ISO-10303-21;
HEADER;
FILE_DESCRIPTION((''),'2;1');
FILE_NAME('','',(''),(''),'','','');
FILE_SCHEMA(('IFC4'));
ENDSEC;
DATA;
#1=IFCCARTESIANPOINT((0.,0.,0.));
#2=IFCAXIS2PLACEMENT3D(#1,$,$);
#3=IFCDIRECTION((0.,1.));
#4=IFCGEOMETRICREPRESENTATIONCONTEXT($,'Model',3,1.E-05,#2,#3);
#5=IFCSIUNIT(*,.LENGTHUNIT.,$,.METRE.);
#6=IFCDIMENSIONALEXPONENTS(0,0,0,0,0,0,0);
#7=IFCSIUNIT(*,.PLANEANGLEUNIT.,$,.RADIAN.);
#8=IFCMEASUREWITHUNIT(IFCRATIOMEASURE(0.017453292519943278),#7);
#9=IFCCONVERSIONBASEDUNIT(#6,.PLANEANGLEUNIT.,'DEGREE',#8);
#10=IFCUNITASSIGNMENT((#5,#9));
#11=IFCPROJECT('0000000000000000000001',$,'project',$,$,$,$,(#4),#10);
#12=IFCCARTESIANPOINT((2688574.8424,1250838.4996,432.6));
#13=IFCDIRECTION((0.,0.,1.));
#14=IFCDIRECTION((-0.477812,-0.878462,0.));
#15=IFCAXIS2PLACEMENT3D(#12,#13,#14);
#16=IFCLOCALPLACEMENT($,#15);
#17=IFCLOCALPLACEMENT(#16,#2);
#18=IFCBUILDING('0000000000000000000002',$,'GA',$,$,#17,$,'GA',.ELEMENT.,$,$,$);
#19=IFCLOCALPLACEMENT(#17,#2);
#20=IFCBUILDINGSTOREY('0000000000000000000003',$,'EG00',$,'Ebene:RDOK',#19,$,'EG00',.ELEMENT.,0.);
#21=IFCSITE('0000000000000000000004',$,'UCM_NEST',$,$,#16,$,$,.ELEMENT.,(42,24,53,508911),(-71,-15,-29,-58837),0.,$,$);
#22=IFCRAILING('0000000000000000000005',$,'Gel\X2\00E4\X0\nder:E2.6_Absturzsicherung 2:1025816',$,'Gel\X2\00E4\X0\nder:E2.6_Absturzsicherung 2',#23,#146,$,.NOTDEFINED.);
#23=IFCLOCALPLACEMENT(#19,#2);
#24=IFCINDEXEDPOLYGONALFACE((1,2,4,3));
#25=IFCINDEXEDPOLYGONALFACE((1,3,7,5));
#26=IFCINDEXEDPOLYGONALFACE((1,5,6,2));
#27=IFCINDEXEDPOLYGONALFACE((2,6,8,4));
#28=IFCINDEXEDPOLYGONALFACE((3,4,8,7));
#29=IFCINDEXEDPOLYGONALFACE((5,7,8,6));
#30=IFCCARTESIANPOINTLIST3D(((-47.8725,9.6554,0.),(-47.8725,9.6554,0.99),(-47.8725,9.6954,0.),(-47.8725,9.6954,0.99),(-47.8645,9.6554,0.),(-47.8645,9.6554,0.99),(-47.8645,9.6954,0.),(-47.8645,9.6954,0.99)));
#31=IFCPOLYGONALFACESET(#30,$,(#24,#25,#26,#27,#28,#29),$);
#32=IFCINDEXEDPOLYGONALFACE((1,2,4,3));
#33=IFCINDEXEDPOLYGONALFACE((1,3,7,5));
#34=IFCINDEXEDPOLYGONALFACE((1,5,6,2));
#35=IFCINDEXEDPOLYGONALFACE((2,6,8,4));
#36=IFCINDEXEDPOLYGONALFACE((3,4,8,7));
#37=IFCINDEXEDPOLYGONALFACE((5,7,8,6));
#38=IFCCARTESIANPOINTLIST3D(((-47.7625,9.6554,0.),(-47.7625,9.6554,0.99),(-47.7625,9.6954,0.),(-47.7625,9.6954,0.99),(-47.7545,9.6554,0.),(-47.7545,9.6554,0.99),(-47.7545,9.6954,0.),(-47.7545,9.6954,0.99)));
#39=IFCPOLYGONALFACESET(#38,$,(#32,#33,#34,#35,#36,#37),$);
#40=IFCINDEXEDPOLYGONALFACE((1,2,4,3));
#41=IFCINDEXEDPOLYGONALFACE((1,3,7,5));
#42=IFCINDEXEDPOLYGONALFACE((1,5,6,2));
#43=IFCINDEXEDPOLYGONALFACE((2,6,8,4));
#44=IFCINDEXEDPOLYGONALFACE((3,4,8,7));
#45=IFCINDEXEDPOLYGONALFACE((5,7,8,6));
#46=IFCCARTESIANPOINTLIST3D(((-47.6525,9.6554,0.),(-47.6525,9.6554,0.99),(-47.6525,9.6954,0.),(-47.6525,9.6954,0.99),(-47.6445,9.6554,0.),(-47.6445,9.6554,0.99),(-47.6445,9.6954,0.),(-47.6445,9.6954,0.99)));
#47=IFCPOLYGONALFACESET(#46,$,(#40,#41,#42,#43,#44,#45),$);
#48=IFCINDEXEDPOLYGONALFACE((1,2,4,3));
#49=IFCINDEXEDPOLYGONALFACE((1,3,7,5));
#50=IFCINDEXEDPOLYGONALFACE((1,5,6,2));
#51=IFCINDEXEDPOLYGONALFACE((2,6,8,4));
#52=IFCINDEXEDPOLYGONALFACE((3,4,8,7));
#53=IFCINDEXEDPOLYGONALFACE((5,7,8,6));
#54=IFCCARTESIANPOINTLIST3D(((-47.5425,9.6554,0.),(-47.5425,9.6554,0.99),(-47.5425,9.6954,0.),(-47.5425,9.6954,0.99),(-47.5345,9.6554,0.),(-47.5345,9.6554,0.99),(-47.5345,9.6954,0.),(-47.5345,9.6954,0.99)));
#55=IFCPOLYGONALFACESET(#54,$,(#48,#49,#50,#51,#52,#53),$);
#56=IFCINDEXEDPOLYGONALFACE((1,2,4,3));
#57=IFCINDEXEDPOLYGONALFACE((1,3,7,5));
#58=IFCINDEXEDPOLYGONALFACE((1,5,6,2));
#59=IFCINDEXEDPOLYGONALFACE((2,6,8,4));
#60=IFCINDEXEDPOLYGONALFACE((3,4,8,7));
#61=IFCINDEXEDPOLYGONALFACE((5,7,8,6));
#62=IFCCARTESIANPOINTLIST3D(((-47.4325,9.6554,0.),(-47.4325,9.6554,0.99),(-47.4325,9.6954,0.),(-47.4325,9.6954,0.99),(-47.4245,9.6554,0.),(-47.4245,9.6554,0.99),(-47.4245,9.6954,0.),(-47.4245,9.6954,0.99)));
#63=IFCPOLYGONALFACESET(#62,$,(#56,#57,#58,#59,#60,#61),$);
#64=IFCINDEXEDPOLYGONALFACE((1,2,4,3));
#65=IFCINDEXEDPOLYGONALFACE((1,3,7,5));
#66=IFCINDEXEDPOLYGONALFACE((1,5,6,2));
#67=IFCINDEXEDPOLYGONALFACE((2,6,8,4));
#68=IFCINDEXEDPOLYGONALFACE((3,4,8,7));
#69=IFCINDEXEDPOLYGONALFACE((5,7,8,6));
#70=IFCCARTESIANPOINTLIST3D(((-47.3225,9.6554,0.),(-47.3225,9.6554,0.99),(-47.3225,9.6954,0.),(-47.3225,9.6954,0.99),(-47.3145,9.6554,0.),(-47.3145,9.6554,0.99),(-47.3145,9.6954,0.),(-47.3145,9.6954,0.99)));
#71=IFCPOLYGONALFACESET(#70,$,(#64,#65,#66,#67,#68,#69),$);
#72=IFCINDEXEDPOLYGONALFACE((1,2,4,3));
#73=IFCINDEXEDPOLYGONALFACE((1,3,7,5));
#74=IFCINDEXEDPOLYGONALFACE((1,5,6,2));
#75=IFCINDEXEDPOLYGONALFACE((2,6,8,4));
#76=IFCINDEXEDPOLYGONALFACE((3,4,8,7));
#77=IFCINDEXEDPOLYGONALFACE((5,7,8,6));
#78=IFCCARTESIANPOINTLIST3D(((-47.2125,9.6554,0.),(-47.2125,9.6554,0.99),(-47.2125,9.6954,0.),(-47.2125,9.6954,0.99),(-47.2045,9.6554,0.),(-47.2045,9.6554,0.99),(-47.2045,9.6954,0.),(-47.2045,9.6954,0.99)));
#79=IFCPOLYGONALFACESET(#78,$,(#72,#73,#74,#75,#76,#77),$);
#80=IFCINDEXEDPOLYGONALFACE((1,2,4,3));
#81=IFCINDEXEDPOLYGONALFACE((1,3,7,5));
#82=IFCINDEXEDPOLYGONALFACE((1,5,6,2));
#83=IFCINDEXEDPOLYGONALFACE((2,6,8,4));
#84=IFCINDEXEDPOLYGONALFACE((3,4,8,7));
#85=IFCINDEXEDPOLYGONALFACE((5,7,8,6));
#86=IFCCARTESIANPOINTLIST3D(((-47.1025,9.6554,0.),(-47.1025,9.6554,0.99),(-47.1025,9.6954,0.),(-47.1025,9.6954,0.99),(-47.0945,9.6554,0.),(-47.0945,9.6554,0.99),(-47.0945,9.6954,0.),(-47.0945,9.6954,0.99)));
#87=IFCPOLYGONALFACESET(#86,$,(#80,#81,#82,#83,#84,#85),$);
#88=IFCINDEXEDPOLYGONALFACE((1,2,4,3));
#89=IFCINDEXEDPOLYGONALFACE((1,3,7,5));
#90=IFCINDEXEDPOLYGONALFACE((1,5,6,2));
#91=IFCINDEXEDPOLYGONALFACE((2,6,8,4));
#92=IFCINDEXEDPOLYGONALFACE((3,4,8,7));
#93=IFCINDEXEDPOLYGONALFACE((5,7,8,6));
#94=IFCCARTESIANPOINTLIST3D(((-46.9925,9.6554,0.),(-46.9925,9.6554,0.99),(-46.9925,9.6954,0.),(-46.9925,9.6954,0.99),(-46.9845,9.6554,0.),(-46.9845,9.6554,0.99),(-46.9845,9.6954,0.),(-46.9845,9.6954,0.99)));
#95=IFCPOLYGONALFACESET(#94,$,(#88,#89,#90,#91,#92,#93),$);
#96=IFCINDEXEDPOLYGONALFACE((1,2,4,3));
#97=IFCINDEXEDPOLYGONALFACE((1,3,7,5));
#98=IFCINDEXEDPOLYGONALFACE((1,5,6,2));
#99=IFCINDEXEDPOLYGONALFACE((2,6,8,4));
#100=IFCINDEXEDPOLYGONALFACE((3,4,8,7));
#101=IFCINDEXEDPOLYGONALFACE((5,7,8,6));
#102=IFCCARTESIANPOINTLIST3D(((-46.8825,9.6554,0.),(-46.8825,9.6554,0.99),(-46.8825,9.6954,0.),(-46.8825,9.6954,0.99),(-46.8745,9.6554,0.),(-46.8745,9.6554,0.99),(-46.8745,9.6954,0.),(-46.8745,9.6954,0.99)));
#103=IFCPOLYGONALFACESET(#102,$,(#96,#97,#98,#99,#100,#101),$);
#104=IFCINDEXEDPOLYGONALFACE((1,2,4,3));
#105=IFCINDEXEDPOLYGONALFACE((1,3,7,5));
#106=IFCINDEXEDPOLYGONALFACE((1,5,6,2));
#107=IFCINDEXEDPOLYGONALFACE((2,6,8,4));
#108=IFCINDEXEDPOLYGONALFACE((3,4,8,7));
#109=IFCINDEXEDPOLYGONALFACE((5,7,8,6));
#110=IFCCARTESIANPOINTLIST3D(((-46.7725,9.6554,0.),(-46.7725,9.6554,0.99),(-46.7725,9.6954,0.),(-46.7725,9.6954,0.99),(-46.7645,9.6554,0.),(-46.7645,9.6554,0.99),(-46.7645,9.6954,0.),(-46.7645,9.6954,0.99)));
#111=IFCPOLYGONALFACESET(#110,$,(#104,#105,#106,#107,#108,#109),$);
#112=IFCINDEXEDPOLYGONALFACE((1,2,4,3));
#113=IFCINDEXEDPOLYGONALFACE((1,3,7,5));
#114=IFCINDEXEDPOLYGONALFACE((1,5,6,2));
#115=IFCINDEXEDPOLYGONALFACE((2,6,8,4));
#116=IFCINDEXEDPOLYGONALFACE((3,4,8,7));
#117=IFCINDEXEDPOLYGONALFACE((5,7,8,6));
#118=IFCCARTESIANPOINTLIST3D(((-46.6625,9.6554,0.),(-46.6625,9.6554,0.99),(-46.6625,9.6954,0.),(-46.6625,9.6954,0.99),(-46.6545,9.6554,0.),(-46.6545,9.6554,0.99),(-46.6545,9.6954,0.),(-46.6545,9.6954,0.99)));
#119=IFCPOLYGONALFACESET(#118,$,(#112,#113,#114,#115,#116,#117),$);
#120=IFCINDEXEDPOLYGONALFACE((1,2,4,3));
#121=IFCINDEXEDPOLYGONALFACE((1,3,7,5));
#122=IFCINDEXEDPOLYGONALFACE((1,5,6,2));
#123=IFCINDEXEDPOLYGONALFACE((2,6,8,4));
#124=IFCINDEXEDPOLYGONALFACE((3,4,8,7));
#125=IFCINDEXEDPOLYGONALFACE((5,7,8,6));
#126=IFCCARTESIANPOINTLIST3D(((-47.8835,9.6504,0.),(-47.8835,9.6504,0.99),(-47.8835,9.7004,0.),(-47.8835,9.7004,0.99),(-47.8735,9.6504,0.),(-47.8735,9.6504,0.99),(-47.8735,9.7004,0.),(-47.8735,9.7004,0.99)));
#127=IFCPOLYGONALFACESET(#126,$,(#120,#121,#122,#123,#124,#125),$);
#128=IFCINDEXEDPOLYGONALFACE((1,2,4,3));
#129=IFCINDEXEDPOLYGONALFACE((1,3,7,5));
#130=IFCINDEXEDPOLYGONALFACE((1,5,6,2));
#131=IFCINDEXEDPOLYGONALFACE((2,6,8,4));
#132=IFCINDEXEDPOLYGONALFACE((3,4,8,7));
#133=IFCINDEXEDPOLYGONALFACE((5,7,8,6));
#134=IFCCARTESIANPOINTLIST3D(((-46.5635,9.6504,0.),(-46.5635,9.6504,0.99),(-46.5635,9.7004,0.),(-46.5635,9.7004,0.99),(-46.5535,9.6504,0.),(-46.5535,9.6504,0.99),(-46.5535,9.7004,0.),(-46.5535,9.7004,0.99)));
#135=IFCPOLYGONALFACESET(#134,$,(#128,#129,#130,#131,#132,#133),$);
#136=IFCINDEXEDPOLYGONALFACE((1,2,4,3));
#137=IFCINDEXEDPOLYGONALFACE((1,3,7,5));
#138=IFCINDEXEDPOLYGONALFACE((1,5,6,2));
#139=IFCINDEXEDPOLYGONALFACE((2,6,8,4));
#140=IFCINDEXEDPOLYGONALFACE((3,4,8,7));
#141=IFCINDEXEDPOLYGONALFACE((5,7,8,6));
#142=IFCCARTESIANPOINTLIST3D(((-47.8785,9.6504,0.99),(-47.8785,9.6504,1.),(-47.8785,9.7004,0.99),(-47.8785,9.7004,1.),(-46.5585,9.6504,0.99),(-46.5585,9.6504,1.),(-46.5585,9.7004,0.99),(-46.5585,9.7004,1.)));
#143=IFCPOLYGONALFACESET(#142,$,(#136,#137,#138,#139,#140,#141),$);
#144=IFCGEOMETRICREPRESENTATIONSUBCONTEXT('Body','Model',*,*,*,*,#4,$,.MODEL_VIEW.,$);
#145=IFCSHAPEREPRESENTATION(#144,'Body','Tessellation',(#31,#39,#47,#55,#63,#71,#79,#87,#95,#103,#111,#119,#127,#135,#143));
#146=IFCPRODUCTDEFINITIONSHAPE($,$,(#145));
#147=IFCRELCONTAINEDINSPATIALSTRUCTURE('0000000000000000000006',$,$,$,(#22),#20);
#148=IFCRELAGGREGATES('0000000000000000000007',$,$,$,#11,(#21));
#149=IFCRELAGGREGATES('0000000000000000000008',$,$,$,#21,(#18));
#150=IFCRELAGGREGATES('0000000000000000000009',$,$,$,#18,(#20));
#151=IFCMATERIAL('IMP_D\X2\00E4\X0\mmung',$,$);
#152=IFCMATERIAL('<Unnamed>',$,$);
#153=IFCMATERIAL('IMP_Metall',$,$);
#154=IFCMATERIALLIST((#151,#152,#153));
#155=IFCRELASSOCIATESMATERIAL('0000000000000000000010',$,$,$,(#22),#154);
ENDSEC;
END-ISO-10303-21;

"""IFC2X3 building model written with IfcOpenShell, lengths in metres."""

from ifc_helpers import new_model, entity, si_unit, converted_unit, direction, frame, frame_2d, origin, origin_2d_with_axis, place, context, subcontext, project, spatial, rectangle, extrude, material, material_list, element, save


model = new_model("IFC2X3")

# Units and contexts
model_context = context("Model", 3, precision=1e-05, world=origin(), true_north=direction((0.0, 1.0)))
body_context = subcontext(model_context, "Body", "Model", "MODEL_VIEW")
ifc_project = project(units=[si_unit("LENGTHUNIT", "METRE"), converted_unit("PLANEANGLEUNIT", "DEGREE", entity("IfcRatioMeasure", 0.017453292519943278), si_unit("PLANEANGLEUNIT", "RADIAN"), dimensions=[0, 0, 0, 0, 0, 0, 0])], contexts=[model_context])

# Site, building, storey
site_placement = place(None, frame((2688574.8424, 1250838.4996, 432.6), z_axis=(0.0, 0.0, 1.0), x_axis=(-0.477812, -0.878462, 0.0)))
site = spatial("IfcSite", under=ifc_project, at=site_placement, Name="UCM_NEST", CompositionType="ELEMENT", RefLatitude=(42, 24, 53, 508911), RefLongitude=(-71, -15, -29, -58837), RefElevation=0.0)
building_placement = place(site_placement, origin())
building = spatial("IfcBuilding", under=site, at=building_placement, Name="GA", LongName="GA", CompositionType="ELEMENT")
storey_placement = place(building_placement, origin())
storey = spatial("IfcBuildingStorey", under=building, at=storey_placement, Name="EG00", ObjectType="Ebene:RDOK", LongName="EG00", CompositionType="ELEMENT", Elevation=0.0)

# Shared definitions
ifc_material_1 = material(Name="IMP_Dämmung")

# Railing
ifc_material_2 = material(Name="<Unnamed>")
ifc_material_3 = material(Name="IMP_Metall")
ifc_material_list = material_list([ifc_material_1, ifc_material_2, ifc_material_3])
railing_1_placement = place(storey_placement, origin())
element("IfcRailing", 1, at=railing_1_placement, inside=storey, material=ifc_material_list, Name="Geländer:E2.6_Absturzsicherung 2:1025816", ObjectType="Geländer:E2.6_Absturzsicherung 2", PredefinedType="NOTDEFINED", context=body_context, shape_type="SweptSolid", body=[
    extrude(rectangle(XDim=0.008, YDim=0.04, at=origin_2d_with_axis()), frame((-47.8685, 9.6754, 0.0), z_axis=(0.0, 0.0, 1.0), x_axis=(-1.0, 0.0, 0.0)), (0.0, 0.0, 1.0), 0.99),
    extrude(rectangle(XDim=0.008, YDim=0.04, at=origin_2d_with_axis()), frame((-47.7585, 9.6754, 0.0), z_axis=(0.0, 0.0, 1.0), x_axis=(-1.0, 0.0, 0.0)), (0.0, 0.0, 1.0), 0.99),
    extrude(rectangle(XDim=0.008, YDim=0.04, at=origin_2d_with_axis()), frame((-47.6485, 9.6754, 0.0), z_axis=(0.0, 0.0, 1.0), x_axis=(-1.0, 0.0, 0.0)), (0.0, 0.0, 1.0), 0.99),
    extrude(rectangle(XDim=0.008, YDim=0.04, at=origin_2d_with_axis()), frame((-47.5385, 9.6754, 0.0), z_axis=(0.0, 0.0, 1.0), x_axis=(-1.0, 0.0, 0.0)), (0.0, 0.0, 1.0), 0.99),
    extrude(rectangle(XDim=0.008, YDim=0.04, at=origin_2d_with_axis()), frame((-47.4285, 9.6754, 0.0), z_axis=(0.0, 0.0, 1.0), x_axis=(-1.0, 0.0, 0.0)), (0.0, 0.0, 1.0), 0.99),
    extrude(rectangle(XDim=0.008, YDim=0.04, at=origin_2d_with_axis()), frame((-47.3185, 9.6754, 0.0), z_axis=(0.0, 0.0, 1.0), x_axis=(-1.0, 0.0, 0.0)), (0.0, 0.0, 1.0), 0.99),
    extrude(rectangle(XDim=0.008, YDim=0.04, at=origin_2d_with_axis()), frame((-47.2085, 9.6754, 0.0), z_axis=(0.0, 0.0, 1.0), x_axis=(-1.0, 0.0, 0.0)), (0.0, 0.0, 1.0), 0.99),
    extrude(rectangle(XDim=0.008, YDim=0.04, at=origin_2d_with_axis()), frame((-47.0985, 9.6754, 0.0), z_axis=(0.0, 0.0, 1.0), x_axis=(-1.0, 0.0, 0.0)), (0.0, 0.0, 1.0), 0.99),
    extrude(rectangle(XDim=0.008, YDim=0.04, at=origin_2d_with_axis()), frame((-46.9885, 9.6754, 0.0), z_axis=(0.0, 0.0, 1.0), x_axis=(-1.0, 0.0, 0.0)), (0.0, 0.0, 1.0), 0.99),
    extrude(rectangle(XDim=0.008, YDim=0.04, at=origin_2d_with_axis()), frame((-46.8785, 9.6754, 0.0), z_axis=(0.0, 0.0, 1.0), x_axis=(-1.0, 0.0, 0.0)), (0.0, 0.0, 1.0), 0.99),
    extrude(rectangle(XDim=0.008, YDim=0.04, at=origin_2d_with_axis()), frame((-46.7685, 9.6754, 0.0), z_axis=(0.0, 0.0, 1.0), x_axis=(-1.0, 0.0, 0.0)), (0.0, 0.0, 1.0), 0.99),
    extrude(rectangle(XDim=0.008, YDim=0.04, at=origin_2d_with_axis()), frame((-46.6585, 9.6754, 0.0), z_axis=(0.0, 0.0, 1.0), x_axis=(-1.0, 0.0, 0.0)), (0.0, 0.0, 1.0), 0.99),
    extrude(rectangle(XDim=0.01, YDim=0.05, at=frame_2d((0.0, 0.0), x_axis=(1.0, 0.0))), frame((-47.8785, 9.6754, 0.0), z_axis=(0.0, 0.0, 1.0), x_axis=(-1.0, 0.0, 0.0)), (0.0, 0.0, 1.0), 0.99),
    extrude(rectangle(XDim=0.01, YDim=0.05, at=frame_2d((0.0, 0.0), x_axis=(1.0, 0.0))), frame((-46.5585, 9.6754, 0.0), z_axis=(0.0, 0.0, 1.0), x_axis=(-1.0, 0.0, 0.0)), (0.0, 0.0, 1.0), 0.99),
    extrude(rectangle(XDim=1.32, YDim=0.05, at=frame_2d((0.0, 0.0), x_axis=(1.0, 0.0))), frame((-47.2185, 9.6754, 0.99), z_axis=(0.0, 0.0, 1.0), x_axis=(-1.0, 0.0, 0.0)), (0.0, 0.0, 1.0), 0.01),
])

save(model, "model.ifc")
